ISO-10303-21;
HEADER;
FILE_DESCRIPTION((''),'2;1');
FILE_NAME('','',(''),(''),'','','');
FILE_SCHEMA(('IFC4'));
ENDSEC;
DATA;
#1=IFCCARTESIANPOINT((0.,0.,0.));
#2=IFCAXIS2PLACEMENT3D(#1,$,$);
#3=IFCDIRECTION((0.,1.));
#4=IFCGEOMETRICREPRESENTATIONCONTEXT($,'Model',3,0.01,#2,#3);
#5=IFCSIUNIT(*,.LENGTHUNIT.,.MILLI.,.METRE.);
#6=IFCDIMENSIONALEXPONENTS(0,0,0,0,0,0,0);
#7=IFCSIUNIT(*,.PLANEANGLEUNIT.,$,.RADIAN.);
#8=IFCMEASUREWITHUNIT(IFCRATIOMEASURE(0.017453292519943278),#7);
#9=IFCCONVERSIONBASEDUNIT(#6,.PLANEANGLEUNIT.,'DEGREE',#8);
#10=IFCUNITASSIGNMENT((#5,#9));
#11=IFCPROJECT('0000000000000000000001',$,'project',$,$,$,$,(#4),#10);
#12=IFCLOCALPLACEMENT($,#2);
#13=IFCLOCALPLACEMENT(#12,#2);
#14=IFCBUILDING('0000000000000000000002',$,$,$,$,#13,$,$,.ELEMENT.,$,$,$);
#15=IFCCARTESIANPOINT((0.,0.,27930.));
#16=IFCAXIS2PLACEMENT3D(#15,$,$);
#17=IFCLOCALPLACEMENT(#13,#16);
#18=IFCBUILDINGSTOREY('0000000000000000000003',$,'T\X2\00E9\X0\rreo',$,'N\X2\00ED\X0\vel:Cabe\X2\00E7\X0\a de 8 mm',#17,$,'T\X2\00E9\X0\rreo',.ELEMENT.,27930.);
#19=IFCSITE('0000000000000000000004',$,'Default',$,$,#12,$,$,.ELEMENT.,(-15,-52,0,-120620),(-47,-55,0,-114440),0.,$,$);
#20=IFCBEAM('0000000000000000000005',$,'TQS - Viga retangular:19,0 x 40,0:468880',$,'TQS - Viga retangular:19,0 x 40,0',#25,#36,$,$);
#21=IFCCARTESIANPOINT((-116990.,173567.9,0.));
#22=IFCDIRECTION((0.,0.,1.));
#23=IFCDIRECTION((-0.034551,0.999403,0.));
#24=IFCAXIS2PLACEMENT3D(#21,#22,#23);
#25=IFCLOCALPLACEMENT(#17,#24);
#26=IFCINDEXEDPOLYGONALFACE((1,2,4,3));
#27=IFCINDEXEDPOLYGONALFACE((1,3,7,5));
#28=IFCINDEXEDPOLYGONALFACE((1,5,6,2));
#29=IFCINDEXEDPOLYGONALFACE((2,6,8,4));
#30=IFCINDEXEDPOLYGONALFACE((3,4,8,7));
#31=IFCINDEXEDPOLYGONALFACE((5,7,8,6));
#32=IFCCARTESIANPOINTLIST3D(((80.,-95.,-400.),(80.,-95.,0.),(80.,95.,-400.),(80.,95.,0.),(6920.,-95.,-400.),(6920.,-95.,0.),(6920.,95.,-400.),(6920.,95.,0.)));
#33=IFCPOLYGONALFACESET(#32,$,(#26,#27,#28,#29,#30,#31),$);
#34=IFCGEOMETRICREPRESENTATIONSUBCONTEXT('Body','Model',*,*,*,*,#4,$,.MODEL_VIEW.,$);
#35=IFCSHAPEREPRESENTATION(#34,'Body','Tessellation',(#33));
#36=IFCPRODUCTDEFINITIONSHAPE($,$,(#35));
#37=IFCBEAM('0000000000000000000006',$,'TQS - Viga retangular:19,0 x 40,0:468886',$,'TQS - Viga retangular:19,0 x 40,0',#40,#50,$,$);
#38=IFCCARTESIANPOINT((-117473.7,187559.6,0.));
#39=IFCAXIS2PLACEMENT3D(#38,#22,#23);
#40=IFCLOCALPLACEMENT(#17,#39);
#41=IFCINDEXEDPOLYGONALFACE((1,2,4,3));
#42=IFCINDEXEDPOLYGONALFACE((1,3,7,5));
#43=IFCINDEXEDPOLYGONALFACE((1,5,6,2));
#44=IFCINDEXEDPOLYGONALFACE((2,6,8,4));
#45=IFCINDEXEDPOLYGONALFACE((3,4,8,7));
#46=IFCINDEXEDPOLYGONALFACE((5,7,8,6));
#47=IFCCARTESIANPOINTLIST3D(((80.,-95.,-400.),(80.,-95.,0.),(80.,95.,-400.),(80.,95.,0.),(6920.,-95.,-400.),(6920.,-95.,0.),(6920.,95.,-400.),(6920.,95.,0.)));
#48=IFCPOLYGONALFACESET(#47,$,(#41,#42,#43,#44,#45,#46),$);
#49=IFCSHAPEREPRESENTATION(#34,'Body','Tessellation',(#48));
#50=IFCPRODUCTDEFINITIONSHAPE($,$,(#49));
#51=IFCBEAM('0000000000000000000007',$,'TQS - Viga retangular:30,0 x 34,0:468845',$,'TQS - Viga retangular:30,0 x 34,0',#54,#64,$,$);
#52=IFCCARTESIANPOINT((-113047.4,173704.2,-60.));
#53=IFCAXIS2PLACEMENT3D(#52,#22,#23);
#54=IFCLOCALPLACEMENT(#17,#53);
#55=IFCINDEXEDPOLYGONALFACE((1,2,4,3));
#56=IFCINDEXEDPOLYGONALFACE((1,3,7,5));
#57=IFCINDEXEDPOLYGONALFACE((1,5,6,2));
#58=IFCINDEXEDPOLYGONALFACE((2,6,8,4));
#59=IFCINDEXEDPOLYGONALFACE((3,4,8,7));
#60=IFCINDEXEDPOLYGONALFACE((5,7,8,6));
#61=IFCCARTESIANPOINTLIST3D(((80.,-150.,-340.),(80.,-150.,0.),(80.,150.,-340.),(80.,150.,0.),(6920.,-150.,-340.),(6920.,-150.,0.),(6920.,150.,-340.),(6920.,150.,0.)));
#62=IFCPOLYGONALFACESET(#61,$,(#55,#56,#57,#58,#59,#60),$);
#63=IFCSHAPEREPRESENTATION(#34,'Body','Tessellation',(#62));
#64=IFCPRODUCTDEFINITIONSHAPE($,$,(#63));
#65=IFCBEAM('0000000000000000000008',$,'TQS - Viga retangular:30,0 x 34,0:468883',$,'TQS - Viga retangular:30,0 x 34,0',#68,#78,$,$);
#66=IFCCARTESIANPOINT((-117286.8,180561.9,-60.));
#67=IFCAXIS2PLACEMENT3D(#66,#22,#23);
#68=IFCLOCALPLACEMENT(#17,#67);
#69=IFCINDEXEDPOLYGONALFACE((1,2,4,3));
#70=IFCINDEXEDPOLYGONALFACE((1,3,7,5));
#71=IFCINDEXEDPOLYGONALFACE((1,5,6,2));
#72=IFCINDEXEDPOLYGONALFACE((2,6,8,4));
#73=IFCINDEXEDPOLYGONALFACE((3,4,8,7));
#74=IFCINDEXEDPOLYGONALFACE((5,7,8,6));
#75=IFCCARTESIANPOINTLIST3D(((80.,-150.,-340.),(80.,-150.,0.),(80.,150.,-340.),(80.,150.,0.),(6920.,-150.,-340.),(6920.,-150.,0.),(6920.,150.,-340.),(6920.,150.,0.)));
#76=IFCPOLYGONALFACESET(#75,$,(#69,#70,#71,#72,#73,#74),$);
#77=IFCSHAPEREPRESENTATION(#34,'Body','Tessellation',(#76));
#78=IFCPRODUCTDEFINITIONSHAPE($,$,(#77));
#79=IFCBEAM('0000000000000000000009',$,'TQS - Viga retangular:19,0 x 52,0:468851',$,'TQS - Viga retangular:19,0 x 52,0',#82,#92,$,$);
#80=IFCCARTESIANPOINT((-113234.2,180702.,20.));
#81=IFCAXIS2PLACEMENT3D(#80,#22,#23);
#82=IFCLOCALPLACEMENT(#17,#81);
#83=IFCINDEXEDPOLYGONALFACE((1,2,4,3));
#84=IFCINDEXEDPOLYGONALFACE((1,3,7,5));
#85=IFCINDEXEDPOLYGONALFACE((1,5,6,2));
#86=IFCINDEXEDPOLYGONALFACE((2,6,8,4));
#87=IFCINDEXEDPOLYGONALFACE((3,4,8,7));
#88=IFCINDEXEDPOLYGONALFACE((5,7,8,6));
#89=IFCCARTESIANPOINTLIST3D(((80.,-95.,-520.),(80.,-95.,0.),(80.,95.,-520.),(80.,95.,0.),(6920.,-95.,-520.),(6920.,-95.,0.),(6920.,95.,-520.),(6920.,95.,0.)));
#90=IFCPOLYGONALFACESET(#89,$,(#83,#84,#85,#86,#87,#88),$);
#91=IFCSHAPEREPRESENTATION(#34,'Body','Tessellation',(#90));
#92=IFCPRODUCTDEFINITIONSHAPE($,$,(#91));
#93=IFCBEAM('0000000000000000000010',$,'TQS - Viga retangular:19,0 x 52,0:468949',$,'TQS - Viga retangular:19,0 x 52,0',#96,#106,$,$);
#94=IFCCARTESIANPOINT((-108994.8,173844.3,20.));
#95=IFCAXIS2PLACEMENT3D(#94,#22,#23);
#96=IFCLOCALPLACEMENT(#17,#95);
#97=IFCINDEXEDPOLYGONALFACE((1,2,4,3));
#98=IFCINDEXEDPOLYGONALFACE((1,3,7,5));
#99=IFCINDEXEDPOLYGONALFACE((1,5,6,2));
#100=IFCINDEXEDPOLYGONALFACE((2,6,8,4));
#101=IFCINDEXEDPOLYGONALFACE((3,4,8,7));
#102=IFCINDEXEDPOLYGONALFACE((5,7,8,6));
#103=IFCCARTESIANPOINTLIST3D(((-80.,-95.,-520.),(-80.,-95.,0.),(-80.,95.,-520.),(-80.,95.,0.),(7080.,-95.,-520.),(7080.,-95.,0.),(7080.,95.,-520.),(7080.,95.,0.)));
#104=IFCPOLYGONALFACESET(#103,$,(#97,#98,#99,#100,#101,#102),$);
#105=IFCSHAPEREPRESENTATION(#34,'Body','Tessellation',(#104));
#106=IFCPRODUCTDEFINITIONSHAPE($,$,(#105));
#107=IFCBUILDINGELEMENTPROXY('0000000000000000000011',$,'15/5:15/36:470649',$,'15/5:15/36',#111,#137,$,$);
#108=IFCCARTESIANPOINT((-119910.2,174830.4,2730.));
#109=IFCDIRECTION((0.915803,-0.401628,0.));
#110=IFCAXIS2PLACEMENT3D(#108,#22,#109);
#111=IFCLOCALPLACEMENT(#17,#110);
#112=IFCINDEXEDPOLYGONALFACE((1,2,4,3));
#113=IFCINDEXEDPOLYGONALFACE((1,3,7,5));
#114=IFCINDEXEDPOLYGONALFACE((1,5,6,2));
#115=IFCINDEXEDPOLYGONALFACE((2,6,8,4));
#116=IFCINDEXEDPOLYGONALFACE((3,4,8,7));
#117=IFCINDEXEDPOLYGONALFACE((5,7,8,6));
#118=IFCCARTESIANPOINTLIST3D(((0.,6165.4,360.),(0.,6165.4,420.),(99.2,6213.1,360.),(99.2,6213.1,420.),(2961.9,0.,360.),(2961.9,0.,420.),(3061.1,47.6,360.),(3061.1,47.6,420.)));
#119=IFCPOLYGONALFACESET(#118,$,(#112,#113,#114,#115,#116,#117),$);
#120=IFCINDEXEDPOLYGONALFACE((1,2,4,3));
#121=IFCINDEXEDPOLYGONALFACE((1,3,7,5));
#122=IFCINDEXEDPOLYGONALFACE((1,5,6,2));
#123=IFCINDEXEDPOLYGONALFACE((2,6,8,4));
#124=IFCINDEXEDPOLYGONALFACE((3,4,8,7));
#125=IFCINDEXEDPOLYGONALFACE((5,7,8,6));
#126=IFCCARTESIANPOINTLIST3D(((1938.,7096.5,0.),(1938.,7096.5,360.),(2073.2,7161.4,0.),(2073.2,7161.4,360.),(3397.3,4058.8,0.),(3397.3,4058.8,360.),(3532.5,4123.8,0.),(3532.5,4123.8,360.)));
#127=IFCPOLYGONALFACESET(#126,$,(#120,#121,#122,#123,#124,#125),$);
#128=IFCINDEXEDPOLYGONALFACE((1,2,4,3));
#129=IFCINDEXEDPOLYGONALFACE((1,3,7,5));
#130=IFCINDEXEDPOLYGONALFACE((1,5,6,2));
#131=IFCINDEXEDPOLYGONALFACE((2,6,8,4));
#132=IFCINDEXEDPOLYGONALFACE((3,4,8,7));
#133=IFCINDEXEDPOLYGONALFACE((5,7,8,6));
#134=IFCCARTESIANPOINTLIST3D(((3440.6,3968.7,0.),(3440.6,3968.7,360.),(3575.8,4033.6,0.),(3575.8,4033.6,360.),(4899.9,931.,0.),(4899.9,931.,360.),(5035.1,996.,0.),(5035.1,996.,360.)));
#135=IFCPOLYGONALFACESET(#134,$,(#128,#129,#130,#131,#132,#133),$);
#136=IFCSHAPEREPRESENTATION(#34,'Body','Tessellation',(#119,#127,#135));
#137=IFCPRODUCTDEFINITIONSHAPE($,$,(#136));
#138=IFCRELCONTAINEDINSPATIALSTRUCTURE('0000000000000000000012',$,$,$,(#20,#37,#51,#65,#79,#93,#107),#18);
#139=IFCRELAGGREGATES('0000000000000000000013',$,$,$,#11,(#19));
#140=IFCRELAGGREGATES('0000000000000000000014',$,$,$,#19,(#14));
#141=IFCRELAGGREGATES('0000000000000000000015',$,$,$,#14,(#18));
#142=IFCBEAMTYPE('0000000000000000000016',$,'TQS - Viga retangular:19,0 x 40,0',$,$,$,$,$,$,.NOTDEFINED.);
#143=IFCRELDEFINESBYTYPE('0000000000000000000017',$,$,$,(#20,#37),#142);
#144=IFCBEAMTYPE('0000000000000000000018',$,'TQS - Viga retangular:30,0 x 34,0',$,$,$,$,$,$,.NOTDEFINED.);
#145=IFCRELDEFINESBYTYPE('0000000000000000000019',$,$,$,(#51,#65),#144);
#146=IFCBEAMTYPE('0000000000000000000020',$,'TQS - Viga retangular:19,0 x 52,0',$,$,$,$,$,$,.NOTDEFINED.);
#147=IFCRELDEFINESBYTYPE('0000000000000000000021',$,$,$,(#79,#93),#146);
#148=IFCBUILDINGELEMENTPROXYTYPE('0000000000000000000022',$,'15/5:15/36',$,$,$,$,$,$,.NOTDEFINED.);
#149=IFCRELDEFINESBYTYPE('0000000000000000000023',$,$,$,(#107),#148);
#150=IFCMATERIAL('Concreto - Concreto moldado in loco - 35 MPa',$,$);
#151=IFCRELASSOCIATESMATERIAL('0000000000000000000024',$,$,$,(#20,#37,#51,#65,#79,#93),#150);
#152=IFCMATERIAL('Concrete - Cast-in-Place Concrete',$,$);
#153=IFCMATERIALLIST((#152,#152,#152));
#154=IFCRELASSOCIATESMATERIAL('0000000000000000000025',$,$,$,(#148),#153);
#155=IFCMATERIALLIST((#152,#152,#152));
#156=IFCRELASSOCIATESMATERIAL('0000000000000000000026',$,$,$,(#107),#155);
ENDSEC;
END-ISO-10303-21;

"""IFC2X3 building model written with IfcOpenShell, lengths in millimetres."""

from ifc_helpers import new_model, entity, si_unit, converted_unit, direction, frame, frame_2d, origin, place, context, subcontext, project, spatial, rectangle, extrude, source, transform, mapped, material, material_list, type_object, type_shapes, element, save


model = new_model("IFC2X3")

# Units and contexts
model_context = context("Model", 3, precision=0.01, world=origin(), true_north=direction((0.0, 1.0)))
body_context = subcontext(model_context, "Body", "Model", "MODEL_VIEW")
ifc_project = project(units=[si_unit("LENGTHUNIT", "METRE", prefix="MILLI"), converted_unit("PLANEANGLEUNIT", "DEGREE", entity("IfcRatioMeasure", 0.017453292519943278), si_unit("PLANEANGLEUNIT", "RADIAN"), dimensions=[0, 0, 0, 0, 0, 0, 0])], contexts=[model_context])

# Site, building, storey
site_placement = place(None, origin())
site = spatial("IfcSite", under=ifc_project, at=site_placement, Name="Default", CompositionType="ELEMENT", RefLatitude=(-15, -52, 0, -120620), RefLongitude=(-47, -55, 0, -114440), RefElevation=0.0)
building_placement = place(site_placement, origin())
building = spatial("IfcBuilding", under=site, at=building_placement, CompositionType="ELEMENT")
storey_placement = place(building_placement, frame((0.0, 0.0, 27930.0)))
storey = spatial("IfcBuildingStorey", under=building, at=storey_placement, Name="Térreo", ObjectType="Nível:Cabeça de 8 mm", LongName="Térreo", CompositionType="ELEMENT", Elevation=27930.0)

# Beams
ifc_material_1 = material(Name="Concreto - Concreto moldado in loco - 35 MPa")
beam_type_1 = type_object("IfcBeamType", Name="TQS - Viga retangular:19,0 x 40,0", PredefinedType="NOTDEFINED")
beam_1_placement = place(storey_placement, frame((-116990.0, 173567.9, 0.0), z_axis=(0.0, 0.0, 1.0), x_axis=(-0.034551, 0.999403, 0.0)))
element("IfcBeam", 1, at=beam_1_placement, inside=storey, type_object=beam_type_1, material=ifc_material_1, Name="TQS - Viga retangular:19,0 x 40,0:468880", ObjectType="TQS - Viga retangular:19,0 x 40,0", context=body_context, shape_type="SweptSolid", body=[
    extrude(rectangle(XDim=400.0, YDim=190.0, at=frame_2d((0.0, 0.0), x_axis=(1.0, 0.0))), frame((80.0, 0.0, -200.0), z_axis=(1.0, 0.0, 0.0), x_axis=(0.0, 0.0, -1.0)), (0.0, 0.0, 1.0), 6840.0),
])
beam_2_placement = place(storey_placement, frame((-117473.7, 187559.6, 0.0), z_axis=(0.0, 0.0, 1.0), x_axis=(-0.034551, 0.999403, 0.0)))
element("IfcBeam", 2, at=beam_2_placement, inside=storey, type_object=beam_type_1, material=ifc_material_1, Name="TQS - Viga retangular:19,0 x 40,0:468886", ObjectType="TQS - Viga retangular:19,0 x 40,0", context=body_context, shape_type="SweptSolid", body=[
    extrude(rectangle(XDim=400.0, YDim=190.0, at=frame_2d((0.0, 0.0), x_axis=(1.0, 0.0))), frame((80.0, 0.0, -200.0), z_axis=(1.0, 0.0, 0.0), x_axis=(0.0, 0.0, -1.0)), (0.0, 0.0, 1.0), 6840.0),
])
beam_type_2 = type_object("IfcBeamType", Name="TQS - Viga retangular:30,0 x 34,0", PredefinedType="NOTDEFINED")
beam_3_placement = place(storey_placement, frame((-113047.4, 173704.2, -60.0), z_axis=(0.0, 0.0, 1.0), x_axis=(-0.034551, 0.999403, 0.0)))
element("IfcBeam", 3, at=beam_3_placement, inside=storey, type_object=beam_type_2, material=ifc_material_1, Name="TQS - Viga retangular:30,0 x 34,0:468845", ObjectType="TQS - Viga retangular:30,0 x 34,0", context=body_context, shape_type="SweptSolid", body=[
    extrude(rectangle(XDim=340.0, YDim=300.0, at=frame_2d((0.0, 0.0), x_axis=(1.0, 0.0))), frame((80.0, 0.0, -170.0), z_axis=(1.0, 0.0, 0.0), x_axis=(0.0, 0.0, -1.0)), (0.0, 0.0, 1.0), 6840.0),
])
beam_4_placement = place(storey_placement, frame((-117286.8, 180561.9, -60.0), z_axis=(0.0, 0.0, 1.0), x_axis=(-0.034551, 0.999403, 0.0)))
element("IfcBeam", 4, at=beam_4_placement, inside=storey, type_object=beam_type_2, material=ifc_material_1, Name="TQS - Viga retangular:30,0 x 34,0:468883", ObjectType="TQS - Viga retangular:30,0 x 34,0", context=body_context, shape_type="SweptSolid", body=[
    extrude(rectangle(XDim=340.0, YDim=300.0, at=frame_2d((0.0, 0.0), x_axis=(1.0, 0.0))), frame((80.0, 0.0, -170.0), z_axis=(1.0, 0.0, 0.0), x_axis=(0.0, 0.0, -1.0)), (0.0, 0.0, 1.0), 6840.0),
])
beam_type_3 = type_object("IfcBeamType", Name="TQS - Viga retangular:19,0 x 52,0", PredefinedType="NOTDEFINED")
beam_5_placement = place(storey_placement, frame((-113234.2, 180702.0, 20.0), z_axis=(0.0, 0.0, 1.0), x_axis=(-0.034551, 0.999403, 0.0)))
element("IfcBeam", 5, at=beam_5_placement, inside=storey, type_object=beam_type_3, material=ifc_material_1, Name="TQS - Viga retangular:19,0 x 52,0:468851", ObjectType="TQS - Viga retangular:19,0 x 52,0", context=body_context, shape_type="SweptSolid", body=[
    extrude(rectangle(XDim=520.0, YDim=190.0, at=frame_2d((0.0, 0.0), x_axis=(1.0, 0.0))), frame((80.0, 0.0, -260.0), z_axis=(1.0, 0.0, 0.0), x_axis=(0.0, 0.0, -1.0)), (0.0, 0.0, 1.0), 6840.0),
])
beam_6_placement = place(storey_placement, frame((-108994.8, 173844.3, 20.0), z_axis=(0.0, 0.0, 1.0), x_axis=(-0.034551, 0.999403, 0.0)))
element("IfcBeam", 6, at=beam_6_placement, inside=storey, type_object=beam_type_3, material=ifc_material_1, Name="TQS - Viga retangular:19,0 x 52,0:468949", ObjectType="TQS - Viga retangular:19,0 x 52,0", context=body_context, shape_type="SweptSolid", body=[
    extrude(rectangle(XDim=520.0, YDim=190.0, at=frame_2d((0.0, 0.0), x_axis=(1.0, 0.0))), frame((-80.0, 0.0, -260.0), z_axis=(1.0, 0.0, 0.0), x_axis=(0.0, 0.0, -1.0)), (0.0, 0.0, 1.0), 7160.0),
])

# Building element proxy
ifc_material_2 = material(Name="Concrete - Cast-in-Place Concrete")
ifc_material_list_1 = material_list([ifc_material_2, ifc_material_2, ifc_material_2])
ifc_material_list_2 = material_list([ifc_material_2, ifc_material_2, ifc_material_2])
building_element_proxy_type_1 = type_object("IfcBuildingElementProxyType", Name="15/5:15/36", PredefinedType="NOTDEFINED", material=ifc_material_list_2)
shared_shape_1 = source(origin(), body_context, "Body", "SweptSolid", [
    extrude(rectangle(XDim=110.0, YDim=6840.0, at=frame_2d((0.0, 0.0), x_axis=(1.0, 0.0))), frame((1530.5, 3106.5, 360.0), z_axis=(0.0, 0.0, 1.0), x_axis=(0.90138, 0.43303, 0.0)), (0.0, 0.0, 1.0), 60.0),
    extrude(rectangle(XDim=3370.0, YDim=150.0, at=frame_2d((0.0, 0.0), x_axis=(1.0, 0.0))), frame((2735.2, 5610.1, 0.0), z_axis=(0.0, 0.0, 1.0), x_axis=(0.43303, -0.90138, 0.0)), (0.0, 0.0, 1.0), 360.0),
    extrude(rectangle(XDim=3370.0, YDim=150.0, at=frame_2d((0.0, 0.0), x_axis=(1.0, 0.0))), frame((4237.8, 2482.3, 0.0), z_axis=(0.0, 0.0, 1.0), x_axis=(0.43303, -0.90138, 0.0)), (0.0, 0.0, 1.0), 360.0),
])
type_shapes(building_element_proxy_type_1, [shared_shape_1])
proxy_1_placement = place(storey_placement, frame((-119910.2, 174830.4, 2730.0), z_axis=(0.0, 0.0, 1.0), x_axis=(0.915803, -0.401628, 0.0)))
element("IfcBuildingElementProxy", 7, at=proxy_1_placement, inside=storey, type_object=building_element_proxy_type_1, material=ifc_material_list_1, Name="15/5:15/36:470649", ObjectType="15/5:15/36", context=body_context, shape_type="MappedRepresentation", body=[
    mapped(shared_shape_1, transform((0.0, 0.0, 0.0), scale=1.0)),
])

save(model, "model.ifc")
